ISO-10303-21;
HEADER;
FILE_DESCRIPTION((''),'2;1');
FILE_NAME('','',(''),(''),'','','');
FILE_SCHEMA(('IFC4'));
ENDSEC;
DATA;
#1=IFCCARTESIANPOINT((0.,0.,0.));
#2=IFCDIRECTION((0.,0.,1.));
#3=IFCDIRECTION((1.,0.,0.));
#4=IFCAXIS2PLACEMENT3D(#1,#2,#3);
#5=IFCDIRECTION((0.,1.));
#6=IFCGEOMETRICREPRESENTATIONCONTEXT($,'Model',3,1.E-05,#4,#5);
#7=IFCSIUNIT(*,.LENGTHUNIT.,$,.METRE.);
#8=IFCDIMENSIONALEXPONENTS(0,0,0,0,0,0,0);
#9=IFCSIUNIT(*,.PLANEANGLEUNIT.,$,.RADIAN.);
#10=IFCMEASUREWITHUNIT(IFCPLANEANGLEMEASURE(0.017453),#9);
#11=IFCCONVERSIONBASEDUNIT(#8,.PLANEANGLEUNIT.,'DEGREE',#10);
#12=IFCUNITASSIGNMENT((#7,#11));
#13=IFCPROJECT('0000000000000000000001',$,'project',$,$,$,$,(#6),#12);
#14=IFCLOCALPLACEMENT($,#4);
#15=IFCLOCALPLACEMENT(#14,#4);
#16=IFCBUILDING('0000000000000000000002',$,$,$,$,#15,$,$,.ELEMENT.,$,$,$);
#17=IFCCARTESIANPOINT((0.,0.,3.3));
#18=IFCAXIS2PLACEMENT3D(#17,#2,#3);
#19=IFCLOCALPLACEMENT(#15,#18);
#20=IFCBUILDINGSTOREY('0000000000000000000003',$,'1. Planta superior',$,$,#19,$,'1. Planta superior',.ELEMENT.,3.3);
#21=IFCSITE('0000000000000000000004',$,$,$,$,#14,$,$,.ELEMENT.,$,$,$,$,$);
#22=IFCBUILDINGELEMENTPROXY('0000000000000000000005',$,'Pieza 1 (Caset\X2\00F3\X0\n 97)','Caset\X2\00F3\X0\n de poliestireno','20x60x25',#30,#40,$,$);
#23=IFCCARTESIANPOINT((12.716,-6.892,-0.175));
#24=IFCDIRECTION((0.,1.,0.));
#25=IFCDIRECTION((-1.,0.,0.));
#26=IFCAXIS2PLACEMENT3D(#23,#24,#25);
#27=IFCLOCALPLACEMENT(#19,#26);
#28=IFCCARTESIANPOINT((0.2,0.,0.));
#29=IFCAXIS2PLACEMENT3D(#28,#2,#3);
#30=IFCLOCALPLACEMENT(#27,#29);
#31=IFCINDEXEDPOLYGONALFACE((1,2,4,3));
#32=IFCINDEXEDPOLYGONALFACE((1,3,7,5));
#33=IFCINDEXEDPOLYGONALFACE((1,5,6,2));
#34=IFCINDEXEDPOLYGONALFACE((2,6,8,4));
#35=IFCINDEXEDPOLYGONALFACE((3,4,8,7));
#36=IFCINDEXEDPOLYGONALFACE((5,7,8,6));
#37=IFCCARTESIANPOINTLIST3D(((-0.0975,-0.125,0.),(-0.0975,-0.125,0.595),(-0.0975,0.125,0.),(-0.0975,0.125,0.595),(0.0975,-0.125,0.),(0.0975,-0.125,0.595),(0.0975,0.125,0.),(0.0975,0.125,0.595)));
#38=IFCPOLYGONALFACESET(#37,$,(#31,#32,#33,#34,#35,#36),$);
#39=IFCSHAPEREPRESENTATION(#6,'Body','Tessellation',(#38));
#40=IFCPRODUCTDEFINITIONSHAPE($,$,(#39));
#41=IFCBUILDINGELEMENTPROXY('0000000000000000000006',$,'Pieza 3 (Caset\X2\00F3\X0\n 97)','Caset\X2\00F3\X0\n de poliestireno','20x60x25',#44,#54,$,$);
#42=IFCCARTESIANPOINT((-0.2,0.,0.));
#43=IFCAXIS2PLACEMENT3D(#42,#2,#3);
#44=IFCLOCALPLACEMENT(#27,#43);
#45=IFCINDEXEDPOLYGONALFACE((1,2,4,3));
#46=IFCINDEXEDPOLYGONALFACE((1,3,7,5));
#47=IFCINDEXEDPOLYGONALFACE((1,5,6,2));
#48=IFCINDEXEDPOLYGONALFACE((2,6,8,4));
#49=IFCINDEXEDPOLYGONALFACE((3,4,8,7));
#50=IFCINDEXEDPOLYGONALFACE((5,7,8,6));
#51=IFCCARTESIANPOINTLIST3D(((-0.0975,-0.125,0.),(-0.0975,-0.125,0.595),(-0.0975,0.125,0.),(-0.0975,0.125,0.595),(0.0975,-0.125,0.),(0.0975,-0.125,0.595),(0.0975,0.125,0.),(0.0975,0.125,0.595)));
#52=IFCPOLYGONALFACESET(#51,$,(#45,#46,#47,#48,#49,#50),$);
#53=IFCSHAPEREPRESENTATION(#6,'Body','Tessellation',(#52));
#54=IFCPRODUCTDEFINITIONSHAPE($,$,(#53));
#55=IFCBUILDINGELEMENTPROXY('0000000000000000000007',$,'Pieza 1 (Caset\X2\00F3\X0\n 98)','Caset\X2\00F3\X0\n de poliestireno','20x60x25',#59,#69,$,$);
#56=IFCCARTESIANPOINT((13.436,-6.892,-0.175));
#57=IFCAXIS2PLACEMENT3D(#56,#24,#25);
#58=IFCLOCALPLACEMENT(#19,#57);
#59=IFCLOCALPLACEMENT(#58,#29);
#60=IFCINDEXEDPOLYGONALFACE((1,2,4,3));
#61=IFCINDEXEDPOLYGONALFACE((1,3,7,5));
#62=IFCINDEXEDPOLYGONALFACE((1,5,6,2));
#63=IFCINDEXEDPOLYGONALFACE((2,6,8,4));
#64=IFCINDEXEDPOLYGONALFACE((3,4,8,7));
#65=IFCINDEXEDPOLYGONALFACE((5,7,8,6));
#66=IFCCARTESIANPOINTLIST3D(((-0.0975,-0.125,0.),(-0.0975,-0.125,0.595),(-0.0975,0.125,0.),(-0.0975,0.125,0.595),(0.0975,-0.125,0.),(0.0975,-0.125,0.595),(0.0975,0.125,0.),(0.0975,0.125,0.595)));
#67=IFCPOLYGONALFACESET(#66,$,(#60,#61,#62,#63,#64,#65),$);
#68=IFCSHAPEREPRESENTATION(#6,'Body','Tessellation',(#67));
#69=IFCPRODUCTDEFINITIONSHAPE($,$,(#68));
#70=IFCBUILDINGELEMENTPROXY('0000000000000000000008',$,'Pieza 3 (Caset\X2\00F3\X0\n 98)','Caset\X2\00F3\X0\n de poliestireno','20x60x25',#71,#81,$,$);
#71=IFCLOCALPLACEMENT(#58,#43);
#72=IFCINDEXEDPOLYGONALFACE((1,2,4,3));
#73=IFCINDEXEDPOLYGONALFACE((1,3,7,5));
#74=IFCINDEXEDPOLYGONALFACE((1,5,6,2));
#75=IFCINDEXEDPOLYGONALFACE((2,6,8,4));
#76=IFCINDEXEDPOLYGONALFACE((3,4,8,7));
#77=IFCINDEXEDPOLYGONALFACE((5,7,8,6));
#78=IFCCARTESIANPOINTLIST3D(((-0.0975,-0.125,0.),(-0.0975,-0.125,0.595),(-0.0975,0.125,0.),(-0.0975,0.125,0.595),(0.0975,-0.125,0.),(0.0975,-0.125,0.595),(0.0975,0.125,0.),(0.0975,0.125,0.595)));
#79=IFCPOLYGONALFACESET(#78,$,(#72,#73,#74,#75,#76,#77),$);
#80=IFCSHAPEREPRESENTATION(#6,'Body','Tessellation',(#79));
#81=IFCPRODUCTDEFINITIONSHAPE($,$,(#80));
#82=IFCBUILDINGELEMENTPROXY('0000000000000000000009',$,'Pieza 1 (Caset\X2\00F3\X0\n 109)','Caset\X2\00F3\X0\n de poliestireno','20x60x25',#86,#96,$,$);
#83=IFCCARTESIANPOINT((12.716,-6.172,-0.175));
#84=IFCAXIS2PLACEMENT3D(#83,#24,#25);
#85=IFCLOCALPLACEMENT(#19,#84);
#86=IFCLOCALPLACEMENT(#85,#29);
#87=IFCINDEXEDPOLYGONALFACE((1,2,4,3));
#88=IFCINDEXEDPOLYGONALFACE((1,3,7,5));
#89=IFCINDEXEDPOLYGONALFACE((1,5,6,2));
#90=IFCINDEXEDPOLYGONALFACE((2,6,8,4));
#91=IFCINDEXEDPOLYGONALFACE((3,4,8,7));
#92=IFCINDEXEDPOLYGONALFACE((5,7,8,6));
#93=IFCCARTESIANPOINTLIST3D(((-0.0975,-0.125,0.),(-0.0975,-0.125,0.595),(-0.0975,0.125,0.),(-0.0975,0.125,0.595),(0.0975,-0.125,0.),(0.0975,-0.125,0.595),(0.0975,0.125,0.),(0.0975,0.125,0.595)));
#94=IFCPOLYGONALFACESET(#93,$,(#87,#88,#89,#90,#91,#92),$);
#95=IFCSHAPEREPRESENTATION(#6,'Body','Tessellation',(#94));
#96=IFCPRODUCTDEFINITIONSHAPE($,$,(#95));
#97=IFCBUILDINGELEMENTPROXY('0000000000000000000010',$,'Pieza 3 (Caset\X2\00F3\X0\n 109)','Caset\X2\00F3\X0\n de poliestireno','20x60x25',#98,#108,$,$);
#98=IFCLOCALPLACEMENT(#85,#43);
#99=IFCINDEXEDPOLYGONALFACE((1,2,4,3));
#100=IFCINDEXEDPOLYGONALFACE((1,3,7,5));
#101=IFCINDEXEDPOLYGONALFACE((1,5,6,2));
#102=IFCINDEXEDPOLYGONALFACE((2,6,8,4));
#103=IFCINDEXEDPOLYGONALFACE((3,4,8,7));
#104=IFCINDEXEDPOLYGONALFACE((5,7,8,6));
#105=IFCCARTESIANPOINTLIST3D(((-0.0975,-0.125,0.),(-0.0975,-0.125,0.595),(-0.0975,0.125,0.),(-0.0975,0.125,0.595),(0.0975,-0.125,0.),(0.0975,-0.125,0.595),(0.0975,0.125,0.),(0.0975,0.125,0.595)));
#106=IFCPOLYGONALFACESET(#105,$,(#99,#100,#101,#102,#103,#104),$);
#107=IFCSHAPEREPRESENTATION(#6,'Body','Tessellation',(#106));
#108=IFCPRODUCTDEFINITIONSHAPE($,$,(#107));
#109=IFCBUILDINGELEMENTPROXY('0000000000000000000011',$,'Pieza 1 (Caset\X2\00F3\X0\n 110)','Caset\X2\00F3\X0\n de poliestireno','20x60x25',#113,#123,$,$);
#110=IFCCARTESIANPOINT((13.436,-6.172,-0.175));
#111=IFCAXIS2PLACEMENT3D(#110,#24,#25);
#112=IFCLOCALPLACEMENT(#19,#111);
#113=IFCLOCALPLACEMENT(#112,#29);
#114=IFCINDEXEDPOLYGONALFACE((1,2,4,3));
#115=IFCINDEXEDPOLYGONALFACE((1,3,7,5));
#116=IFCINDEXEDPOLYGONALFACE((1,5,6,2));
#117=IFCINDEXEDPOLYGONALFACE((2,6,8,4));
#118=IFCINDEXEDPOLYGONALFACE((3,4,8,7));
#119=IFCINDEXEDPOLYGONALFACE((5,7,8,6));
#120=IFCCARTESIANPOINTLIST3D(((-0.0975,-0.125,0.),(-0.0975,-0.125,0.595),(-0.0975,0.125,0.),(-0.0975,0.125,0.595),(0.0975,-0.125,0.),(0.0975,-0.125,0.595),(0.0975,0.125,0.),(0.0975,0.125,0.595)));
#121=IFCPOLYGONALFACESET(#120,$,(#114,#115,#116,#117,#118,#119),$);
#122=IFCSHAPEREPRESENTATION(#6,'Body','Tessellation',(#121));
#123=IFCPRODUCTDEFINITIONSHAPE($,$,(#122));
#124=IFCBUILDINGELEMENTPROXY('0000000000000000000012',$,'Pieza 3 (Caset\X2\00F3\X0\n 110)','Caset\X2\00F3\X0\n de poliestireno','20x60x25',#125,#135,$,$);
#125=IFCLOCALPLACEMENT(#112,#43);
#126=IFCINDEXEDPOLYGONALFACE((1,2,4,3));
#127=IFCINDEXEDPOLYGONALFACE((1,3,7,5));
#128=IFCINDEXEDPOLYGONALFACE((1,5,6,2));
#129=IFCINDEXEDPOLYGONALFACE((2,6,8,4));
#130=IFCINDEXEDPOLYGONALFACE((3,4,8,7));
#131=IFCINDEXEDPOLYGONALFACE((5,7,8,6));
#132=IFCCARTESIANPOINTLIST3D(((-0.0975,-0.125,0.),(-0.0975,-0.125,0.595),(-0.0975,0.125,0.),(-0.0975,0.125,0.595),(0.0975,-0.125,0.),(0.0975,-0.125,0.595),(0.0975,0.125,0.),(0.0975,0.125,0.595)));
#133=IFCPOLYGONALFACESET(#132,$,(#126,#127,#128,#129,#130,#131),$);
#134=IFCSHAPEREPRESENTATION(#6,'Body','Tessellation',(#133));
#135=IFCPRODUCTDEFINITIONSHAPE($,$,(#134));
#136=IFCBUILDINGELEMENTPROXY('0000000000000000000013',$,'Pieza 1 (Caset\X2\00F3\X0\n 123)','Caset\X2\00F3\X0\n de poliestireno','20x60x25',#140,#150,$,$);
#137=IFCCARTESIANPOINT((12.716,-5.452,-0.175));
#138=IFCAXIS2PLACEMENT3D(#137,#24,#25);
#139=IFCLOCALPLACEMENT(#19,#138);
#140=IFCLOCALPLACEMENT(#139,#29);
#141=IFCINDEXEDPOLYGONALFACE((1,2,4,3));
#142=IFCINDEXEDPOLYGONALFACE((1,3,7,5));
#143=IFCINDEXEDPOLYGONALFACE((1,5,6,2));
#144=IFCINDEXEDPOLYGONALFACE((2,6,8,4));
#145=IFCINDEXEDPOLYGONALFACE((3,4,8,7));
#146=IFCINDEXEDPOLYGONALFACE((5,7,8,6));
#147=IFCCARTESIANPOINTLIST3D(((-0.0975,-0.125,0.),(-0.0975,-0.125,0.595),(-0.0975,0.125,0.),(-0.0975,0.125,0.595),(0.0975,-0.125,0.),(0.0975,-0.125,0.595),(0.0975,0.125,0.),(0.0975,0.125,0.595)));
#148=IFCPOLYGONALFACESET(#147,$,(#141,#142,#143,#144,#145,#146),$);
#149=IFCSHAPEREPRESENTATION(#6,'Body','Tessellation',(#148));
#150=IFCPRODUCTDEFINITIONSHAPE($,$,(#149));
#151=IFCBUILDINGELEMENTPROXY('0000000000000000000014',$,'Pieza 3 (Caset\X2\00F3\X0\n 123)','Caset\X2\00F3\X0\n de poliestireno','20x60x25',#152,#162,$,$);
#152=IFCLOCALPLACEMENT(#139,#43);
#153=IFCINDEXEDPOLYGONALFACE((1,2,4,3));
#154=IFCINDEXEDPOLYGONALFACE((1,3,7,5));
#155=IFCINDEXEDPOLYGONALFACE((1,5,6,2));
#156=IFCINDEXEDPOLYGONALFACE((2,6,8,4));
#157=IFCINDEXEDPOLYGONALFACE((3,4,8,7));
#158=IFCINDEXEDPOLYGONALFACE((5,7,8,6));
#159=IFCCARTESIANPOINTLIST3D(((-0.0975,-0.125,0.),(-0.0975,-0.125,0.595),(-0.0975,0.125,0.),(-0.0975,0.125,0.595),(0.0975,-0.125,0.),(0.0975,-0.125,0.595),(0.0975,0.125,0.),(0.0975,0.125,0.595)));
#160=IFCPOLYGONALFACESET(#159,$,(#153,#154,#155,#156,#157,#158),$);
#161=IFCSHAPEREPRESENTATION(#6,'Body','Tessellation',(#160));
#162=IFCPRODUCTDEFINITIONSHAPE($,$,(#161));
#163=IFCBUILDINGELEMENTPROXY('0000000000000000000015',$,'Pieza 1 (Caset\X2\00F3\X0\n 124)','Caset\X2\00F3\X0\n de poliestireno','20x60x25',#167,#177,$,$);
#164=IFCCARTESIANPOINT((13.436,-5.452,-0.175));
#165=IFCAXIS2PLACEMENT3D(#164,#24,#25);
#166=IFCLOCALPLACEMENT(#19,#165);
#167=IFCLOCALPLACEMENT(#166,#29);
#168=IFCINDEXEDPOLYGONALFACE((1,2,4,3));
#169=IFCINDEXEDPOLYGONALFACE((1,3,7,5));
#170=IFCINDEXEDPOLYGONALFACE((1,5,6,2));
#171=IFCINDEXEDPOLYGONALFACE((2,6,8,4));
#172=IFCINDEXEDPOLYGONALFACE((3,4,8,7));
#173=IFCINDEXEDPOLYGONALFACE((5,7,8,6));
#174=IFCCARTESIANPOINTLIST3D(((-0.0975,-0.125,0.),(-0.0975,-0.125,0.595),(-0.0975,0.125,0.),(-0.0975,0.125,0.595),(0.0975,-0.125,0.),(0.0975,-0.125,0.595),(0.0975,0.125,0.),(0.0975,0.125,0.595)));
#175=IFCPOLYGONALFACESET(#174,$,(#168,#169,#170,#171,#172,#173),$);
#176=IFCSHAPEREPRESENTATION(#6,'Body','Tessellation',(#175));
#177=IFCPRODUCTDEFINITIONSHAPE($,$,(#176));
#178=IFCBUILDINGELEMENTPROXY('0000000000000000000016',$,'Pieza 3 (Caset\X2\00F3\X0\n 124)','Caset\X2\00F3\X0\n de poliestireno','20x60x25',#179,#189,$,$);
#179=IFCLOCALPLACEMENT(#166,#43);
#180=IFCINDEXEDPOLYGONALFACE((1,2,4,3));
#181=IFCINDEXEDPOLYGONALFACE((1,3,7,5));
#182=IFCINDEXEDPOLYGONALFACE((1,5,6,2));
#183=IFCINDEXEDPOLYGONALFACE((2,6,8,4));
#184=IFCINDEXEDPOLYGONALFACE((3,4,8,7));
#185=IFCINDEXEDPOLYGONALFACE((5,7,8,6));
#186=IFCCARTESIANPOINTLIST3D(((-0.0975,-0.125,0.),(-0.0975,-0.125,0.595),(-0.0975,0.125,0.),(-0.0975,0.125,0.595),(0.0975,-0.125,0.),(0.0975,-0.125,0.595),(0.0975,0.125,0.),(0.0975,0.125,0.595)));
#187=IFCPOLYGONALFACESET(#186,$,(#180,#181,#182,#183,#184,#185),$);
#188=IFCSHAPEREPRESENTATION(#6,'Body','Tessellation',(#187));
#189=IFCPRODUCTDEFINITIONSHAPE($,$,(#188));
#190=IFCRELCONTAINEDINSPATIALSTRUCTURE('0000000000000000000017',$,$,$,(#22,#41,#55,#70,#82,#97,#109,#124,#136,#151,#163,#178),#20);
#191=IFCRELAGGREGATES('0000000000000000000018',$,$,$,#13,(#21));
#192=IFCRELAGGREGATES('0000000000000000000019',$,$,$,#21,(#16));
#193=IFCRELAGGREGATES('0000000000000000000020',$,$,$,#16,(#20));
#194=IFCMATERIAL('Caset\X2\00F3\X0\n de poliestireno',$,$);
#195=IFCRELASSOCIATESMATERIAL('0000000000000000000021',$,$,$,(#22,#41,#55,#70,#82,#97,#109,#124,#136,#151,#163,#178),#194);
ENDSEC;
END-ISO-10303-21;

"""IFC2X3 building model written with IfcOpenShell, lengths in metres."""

from ifc_helpers import new_model, entity, si_unit, converted_unit, direction, frame, origin_with_axes, origin_2d_with_axis, place, context, project, spatial, rectangle, extrude, source, transform, mapped, material, element, save


model = new_model("IFC2X3")

# Units and contexts
model_context = context("Model", 3, precision=1e-05, world=origin_with_axes(), true_north=direction((0.0, 1.0)))
ifc_project = project(units=[si_unit("LENGTHUNIT", "METRE"), converted_unit("PLANEANGLEUNIT", "DEGREE", entity("IfcPlaneAngleMeasure", 0.017453), si_unit("PLANEANGLEUNIT", "RADIAN"), dimensions=[0, 0, 0, 0, 0, 0, 0])], contexts=[model_context])

# Site, building, storey
site_placement = place(None, origin_with_axes())
site = spatial("IfcSite", under=ifc_project, at=site_placement, CompositionType="ELEMENT")
building_placement = place(site_placement, origin_with_axes())
building = spatial("IfcBuilding", under=site, at=building_placement, CompositionType="ELEMENT")
storey_placement = place(building_placement, frame((0.0, 0.0, 3.3), z_axis=(0.0, 0.0, 1.0), x_axis=(1.0, 0.0, 0.0)))
storey = spatial("IfcBuildingStorey", under=building, at=storey_placement, Name="1. Planta superior", LongName="1. Planta superior", CompositionType="ELEMENT", Elevation=3.3)

# Building element proxies
ifc_material_1 = material(Name="Casetón de poliestireno")
shared_shape = source(origin_with_axes(), model_context, "Body", "SweptSolid", [
    extrude(rectangle(XDim=0.195, YDim=0.25, at=origin_2d_with_axis()), origin_with_axes(), (0.0, 0.0, 1.0), 0.595),
])
placement_1 = place(storey_placement, frame((12.716, -6.892, -0.175), z_axis=(0.0, 1.0, 0.0), x_axis=(-1.0, 0.0, 0.0)))
for number, where, z_axis, x_axis, name in (
    (1, (0.2, 0.0, 0.0), (0.0, 0.0, 1.0), (1.0, 0.0, 0.0), "Pieza 1 (Casetón 97)"),
    (2, (-0.2, 0.0, 0.0), (0.0, 0.0, 1.0), (1.0, 0.0, 0.0), "Pieza 3 (Casetón 97)"),
):
    element("IfcBuildingElementProxy", number, at=place(placement_1, frame(where, z_axis=z_axis, x_axis=x_axis)), inside=storey, material=ifc_material_1, Name=name, Description="Casetón de poliestireno", ObjectType="20x60x25", context=model_context, shape_type="MappedRepresentation", body=[
        mapped(shared_shape, transform((0.0, 0.0, 0.0), x_axis=(1.0, 0.0, 0.0), y_axis=(0.0, 1.0, 0.0), z_axis=(0.0, 0.0, 1.0))),
    ])
placement_2 = place(storey_placement, frame((13.436, -6.892, -0.175), z_axis=(0.0, 1.0, 0.0), x_axis=(-1.0, 0.0, 0.0)))
for number, where, z_axis, x_axis, name in (
    (3, (0.2, 0.0, 0.0), (0.0, 0.0, 1.0), (1.0, 0.0, 0.0), "Pieza 1 (Casetón 98)"),
    (4, (-0.2, 0.0, 0.0), (0.0, 0.0, 1.0), (1.0, 0.0, 0.0), "Pieza 3 (Casetón 98)"),
):
    element("IfcBuildingElementProxy", number, at=place(placement_2, frame(where, z_axis=z_axis, x_axis=x_axis)), inside=storey, material=ifc_material_1, Name=name, Description="Casetón de poliestireno", ObjectType="20x60x25", context=model_context, shape_type="MappedRepresentation", body=[
        mapped(shared_shape, transform((0.0, 0.0, 0.0), x_axis=(1.0, 0.0, 0.0), y_axis=(0.0, 1.0, 0.0), z_axis=(0.0, 0.0, 1.0))),
    ])
placement_3 = place(storey_placement, frame((12.716, -6.172, -0.175), z_axis=(0.0, 1.0, 0.0), x_axis=(-1.0, 0.0, 0.0)))
for number, where, z_axis, x_axis, name in (
    (5, (0.2, 0.0, 0.0), (0.0, 0.0, 1.0), (1.0, 0.0, 0.0), "Pieza 1 (Casetón 109)"),
    (6, (-0.2, 0.0, 0.0), (0.0, 0.0, 1.0), (1.0, 0.0, 0.0), "Pieza 3 (Casetón 109)"),
):
    element("IfcBuildingElementProxy", number, at=place(placement_3, frame(where, z_axis=z_axis, x_axis=x_axis)), inside=storey, material=ifc_material_1, Name=name, Description="Casetón de poliestireno", ObjectType="20x60x25", context=model_context, shape_type="MappedRepresentation", body=[
        mapped(shared_shape, transform((0.0, 0.0, 0.0), x_axis=(1.0, 0.0, 0.0), y_axis=(0.0, 1.0, 0.0), z_axis=(0.0, 0.0, 1.0))),
    ])
placement_4 = place(storey_placement, frame((13.436, -6.172, -0.175), z_axis=(0.0, 1.0, 0.0), x_axis=(-1.0, 0.0, 0.0)))
for number, where, z_axis, x_axis, name in (
    (7, (0.2, 0.0, 0.0), (0.0, 0.0, 1.0), (1.0, 0.0, 0.0), "Pieza 1 (Casetón 110)"),
    (8, (-0.2, 0.0, 0.0), (0.0, 0.0, 1.0), (1.0, 0.0, 0.0), "Pieza 3 (Casetón 110)"),
):
    element("IfcBuildingElementProxy", number, at=place(placement_4, frame(where, z_axis=z_axis, x_axis=x_axis)), inside=storey, material=ifc_material_1, Name=name, Description="Casetón de poliestireno", ObjectType="20x60x25", context=model_context, shape_type="MappedRepresentation", body=[
        mapped(shared_shape, transform((0.0, 0.0, 0.0), x_axis=(1.0, 0.0, 0.0), y_axis=(0.0, 1.0, 0.0), z_axis=(0.0, 0.0, 1.0))),
    ])
placement_5 = place(storey_placement, frame((12.716, -5.452, -0.175), z_axis=(0.0, 1.0, 0.0), x_axis=(-1.0, 0.0, 0.0)))
for number, where, z_axis, x_axis, name in (
    (9, (0.2, 0.0, 0.0), (0.0, 0.0, 1.0), (1.0, 0.0, 0.0), "Pieza 1 (Casetón 123)"),
    (10, (-0.2, 0.0, 0.0), (0.0, 0.0, 1.0), (1.0, 0.0, 0.0), "Pieza 3 (Casetón 123)"),
):
    element("IfcBuildingElementProxy", number, at=place(placement_5, frame(where, z_axis=z_axis, x_axis=x_axis)), inside=storey, material=ifc_material_1, Name=name, Description="Casetón de poliestireno", ObjectType="20x60x25", context=model_context, shape_type="MappedRepresentation", body=[
        mapped(shared_shape, transform((0.0, 0.0, 0.0), x_axis=(1.0, 0.0, 0.0), y_axis=(0.0, 1.0, 0.0), z_axis=(0.0, 0.0, 1.0))),
    ])
placement_6 = place(storey_placement, frame((13.436, -5.452, -0.175), z_axis=(0.0, 1.0, 0.0), x_axis=(-1.0, 0.0, 0.0)))
for number, where, z_axis, x_axis, name in (
    (11, (0.2, 0.0, 0.0), (0.0, 0.0, 1.0), (1.0, 0.0, 0.0), "Pieza 1 (Casetón 124)"),
    (12, (-0.2, 0.0, 0.0), (0.0, 0.0, 1.0), (1.0, 0.0, 0.0), "Pieza 3 (Casetón 124)"),
):
    element("IfcBuildingElementProxy", number, at=place(placement_6, frame(where, z_axis=z_axis, x_axis=x_axis)), inside=storey, material=ifc_material_1, Name=name, Description="Casetón de poliestireno", ObjectType="20x60x25", context=model_context, shape_type="MappedRepresentation", body=[
        mapped(shared_shape, transform((0.0, 0.0, 0.0), x_axis=(1.0, 0.0, 0.0), y_axis=(0.0, 1.0, 0.0), z_axis=(0.0, 0.0, 1.0))),
    ])

save(model, "model.ifc")
